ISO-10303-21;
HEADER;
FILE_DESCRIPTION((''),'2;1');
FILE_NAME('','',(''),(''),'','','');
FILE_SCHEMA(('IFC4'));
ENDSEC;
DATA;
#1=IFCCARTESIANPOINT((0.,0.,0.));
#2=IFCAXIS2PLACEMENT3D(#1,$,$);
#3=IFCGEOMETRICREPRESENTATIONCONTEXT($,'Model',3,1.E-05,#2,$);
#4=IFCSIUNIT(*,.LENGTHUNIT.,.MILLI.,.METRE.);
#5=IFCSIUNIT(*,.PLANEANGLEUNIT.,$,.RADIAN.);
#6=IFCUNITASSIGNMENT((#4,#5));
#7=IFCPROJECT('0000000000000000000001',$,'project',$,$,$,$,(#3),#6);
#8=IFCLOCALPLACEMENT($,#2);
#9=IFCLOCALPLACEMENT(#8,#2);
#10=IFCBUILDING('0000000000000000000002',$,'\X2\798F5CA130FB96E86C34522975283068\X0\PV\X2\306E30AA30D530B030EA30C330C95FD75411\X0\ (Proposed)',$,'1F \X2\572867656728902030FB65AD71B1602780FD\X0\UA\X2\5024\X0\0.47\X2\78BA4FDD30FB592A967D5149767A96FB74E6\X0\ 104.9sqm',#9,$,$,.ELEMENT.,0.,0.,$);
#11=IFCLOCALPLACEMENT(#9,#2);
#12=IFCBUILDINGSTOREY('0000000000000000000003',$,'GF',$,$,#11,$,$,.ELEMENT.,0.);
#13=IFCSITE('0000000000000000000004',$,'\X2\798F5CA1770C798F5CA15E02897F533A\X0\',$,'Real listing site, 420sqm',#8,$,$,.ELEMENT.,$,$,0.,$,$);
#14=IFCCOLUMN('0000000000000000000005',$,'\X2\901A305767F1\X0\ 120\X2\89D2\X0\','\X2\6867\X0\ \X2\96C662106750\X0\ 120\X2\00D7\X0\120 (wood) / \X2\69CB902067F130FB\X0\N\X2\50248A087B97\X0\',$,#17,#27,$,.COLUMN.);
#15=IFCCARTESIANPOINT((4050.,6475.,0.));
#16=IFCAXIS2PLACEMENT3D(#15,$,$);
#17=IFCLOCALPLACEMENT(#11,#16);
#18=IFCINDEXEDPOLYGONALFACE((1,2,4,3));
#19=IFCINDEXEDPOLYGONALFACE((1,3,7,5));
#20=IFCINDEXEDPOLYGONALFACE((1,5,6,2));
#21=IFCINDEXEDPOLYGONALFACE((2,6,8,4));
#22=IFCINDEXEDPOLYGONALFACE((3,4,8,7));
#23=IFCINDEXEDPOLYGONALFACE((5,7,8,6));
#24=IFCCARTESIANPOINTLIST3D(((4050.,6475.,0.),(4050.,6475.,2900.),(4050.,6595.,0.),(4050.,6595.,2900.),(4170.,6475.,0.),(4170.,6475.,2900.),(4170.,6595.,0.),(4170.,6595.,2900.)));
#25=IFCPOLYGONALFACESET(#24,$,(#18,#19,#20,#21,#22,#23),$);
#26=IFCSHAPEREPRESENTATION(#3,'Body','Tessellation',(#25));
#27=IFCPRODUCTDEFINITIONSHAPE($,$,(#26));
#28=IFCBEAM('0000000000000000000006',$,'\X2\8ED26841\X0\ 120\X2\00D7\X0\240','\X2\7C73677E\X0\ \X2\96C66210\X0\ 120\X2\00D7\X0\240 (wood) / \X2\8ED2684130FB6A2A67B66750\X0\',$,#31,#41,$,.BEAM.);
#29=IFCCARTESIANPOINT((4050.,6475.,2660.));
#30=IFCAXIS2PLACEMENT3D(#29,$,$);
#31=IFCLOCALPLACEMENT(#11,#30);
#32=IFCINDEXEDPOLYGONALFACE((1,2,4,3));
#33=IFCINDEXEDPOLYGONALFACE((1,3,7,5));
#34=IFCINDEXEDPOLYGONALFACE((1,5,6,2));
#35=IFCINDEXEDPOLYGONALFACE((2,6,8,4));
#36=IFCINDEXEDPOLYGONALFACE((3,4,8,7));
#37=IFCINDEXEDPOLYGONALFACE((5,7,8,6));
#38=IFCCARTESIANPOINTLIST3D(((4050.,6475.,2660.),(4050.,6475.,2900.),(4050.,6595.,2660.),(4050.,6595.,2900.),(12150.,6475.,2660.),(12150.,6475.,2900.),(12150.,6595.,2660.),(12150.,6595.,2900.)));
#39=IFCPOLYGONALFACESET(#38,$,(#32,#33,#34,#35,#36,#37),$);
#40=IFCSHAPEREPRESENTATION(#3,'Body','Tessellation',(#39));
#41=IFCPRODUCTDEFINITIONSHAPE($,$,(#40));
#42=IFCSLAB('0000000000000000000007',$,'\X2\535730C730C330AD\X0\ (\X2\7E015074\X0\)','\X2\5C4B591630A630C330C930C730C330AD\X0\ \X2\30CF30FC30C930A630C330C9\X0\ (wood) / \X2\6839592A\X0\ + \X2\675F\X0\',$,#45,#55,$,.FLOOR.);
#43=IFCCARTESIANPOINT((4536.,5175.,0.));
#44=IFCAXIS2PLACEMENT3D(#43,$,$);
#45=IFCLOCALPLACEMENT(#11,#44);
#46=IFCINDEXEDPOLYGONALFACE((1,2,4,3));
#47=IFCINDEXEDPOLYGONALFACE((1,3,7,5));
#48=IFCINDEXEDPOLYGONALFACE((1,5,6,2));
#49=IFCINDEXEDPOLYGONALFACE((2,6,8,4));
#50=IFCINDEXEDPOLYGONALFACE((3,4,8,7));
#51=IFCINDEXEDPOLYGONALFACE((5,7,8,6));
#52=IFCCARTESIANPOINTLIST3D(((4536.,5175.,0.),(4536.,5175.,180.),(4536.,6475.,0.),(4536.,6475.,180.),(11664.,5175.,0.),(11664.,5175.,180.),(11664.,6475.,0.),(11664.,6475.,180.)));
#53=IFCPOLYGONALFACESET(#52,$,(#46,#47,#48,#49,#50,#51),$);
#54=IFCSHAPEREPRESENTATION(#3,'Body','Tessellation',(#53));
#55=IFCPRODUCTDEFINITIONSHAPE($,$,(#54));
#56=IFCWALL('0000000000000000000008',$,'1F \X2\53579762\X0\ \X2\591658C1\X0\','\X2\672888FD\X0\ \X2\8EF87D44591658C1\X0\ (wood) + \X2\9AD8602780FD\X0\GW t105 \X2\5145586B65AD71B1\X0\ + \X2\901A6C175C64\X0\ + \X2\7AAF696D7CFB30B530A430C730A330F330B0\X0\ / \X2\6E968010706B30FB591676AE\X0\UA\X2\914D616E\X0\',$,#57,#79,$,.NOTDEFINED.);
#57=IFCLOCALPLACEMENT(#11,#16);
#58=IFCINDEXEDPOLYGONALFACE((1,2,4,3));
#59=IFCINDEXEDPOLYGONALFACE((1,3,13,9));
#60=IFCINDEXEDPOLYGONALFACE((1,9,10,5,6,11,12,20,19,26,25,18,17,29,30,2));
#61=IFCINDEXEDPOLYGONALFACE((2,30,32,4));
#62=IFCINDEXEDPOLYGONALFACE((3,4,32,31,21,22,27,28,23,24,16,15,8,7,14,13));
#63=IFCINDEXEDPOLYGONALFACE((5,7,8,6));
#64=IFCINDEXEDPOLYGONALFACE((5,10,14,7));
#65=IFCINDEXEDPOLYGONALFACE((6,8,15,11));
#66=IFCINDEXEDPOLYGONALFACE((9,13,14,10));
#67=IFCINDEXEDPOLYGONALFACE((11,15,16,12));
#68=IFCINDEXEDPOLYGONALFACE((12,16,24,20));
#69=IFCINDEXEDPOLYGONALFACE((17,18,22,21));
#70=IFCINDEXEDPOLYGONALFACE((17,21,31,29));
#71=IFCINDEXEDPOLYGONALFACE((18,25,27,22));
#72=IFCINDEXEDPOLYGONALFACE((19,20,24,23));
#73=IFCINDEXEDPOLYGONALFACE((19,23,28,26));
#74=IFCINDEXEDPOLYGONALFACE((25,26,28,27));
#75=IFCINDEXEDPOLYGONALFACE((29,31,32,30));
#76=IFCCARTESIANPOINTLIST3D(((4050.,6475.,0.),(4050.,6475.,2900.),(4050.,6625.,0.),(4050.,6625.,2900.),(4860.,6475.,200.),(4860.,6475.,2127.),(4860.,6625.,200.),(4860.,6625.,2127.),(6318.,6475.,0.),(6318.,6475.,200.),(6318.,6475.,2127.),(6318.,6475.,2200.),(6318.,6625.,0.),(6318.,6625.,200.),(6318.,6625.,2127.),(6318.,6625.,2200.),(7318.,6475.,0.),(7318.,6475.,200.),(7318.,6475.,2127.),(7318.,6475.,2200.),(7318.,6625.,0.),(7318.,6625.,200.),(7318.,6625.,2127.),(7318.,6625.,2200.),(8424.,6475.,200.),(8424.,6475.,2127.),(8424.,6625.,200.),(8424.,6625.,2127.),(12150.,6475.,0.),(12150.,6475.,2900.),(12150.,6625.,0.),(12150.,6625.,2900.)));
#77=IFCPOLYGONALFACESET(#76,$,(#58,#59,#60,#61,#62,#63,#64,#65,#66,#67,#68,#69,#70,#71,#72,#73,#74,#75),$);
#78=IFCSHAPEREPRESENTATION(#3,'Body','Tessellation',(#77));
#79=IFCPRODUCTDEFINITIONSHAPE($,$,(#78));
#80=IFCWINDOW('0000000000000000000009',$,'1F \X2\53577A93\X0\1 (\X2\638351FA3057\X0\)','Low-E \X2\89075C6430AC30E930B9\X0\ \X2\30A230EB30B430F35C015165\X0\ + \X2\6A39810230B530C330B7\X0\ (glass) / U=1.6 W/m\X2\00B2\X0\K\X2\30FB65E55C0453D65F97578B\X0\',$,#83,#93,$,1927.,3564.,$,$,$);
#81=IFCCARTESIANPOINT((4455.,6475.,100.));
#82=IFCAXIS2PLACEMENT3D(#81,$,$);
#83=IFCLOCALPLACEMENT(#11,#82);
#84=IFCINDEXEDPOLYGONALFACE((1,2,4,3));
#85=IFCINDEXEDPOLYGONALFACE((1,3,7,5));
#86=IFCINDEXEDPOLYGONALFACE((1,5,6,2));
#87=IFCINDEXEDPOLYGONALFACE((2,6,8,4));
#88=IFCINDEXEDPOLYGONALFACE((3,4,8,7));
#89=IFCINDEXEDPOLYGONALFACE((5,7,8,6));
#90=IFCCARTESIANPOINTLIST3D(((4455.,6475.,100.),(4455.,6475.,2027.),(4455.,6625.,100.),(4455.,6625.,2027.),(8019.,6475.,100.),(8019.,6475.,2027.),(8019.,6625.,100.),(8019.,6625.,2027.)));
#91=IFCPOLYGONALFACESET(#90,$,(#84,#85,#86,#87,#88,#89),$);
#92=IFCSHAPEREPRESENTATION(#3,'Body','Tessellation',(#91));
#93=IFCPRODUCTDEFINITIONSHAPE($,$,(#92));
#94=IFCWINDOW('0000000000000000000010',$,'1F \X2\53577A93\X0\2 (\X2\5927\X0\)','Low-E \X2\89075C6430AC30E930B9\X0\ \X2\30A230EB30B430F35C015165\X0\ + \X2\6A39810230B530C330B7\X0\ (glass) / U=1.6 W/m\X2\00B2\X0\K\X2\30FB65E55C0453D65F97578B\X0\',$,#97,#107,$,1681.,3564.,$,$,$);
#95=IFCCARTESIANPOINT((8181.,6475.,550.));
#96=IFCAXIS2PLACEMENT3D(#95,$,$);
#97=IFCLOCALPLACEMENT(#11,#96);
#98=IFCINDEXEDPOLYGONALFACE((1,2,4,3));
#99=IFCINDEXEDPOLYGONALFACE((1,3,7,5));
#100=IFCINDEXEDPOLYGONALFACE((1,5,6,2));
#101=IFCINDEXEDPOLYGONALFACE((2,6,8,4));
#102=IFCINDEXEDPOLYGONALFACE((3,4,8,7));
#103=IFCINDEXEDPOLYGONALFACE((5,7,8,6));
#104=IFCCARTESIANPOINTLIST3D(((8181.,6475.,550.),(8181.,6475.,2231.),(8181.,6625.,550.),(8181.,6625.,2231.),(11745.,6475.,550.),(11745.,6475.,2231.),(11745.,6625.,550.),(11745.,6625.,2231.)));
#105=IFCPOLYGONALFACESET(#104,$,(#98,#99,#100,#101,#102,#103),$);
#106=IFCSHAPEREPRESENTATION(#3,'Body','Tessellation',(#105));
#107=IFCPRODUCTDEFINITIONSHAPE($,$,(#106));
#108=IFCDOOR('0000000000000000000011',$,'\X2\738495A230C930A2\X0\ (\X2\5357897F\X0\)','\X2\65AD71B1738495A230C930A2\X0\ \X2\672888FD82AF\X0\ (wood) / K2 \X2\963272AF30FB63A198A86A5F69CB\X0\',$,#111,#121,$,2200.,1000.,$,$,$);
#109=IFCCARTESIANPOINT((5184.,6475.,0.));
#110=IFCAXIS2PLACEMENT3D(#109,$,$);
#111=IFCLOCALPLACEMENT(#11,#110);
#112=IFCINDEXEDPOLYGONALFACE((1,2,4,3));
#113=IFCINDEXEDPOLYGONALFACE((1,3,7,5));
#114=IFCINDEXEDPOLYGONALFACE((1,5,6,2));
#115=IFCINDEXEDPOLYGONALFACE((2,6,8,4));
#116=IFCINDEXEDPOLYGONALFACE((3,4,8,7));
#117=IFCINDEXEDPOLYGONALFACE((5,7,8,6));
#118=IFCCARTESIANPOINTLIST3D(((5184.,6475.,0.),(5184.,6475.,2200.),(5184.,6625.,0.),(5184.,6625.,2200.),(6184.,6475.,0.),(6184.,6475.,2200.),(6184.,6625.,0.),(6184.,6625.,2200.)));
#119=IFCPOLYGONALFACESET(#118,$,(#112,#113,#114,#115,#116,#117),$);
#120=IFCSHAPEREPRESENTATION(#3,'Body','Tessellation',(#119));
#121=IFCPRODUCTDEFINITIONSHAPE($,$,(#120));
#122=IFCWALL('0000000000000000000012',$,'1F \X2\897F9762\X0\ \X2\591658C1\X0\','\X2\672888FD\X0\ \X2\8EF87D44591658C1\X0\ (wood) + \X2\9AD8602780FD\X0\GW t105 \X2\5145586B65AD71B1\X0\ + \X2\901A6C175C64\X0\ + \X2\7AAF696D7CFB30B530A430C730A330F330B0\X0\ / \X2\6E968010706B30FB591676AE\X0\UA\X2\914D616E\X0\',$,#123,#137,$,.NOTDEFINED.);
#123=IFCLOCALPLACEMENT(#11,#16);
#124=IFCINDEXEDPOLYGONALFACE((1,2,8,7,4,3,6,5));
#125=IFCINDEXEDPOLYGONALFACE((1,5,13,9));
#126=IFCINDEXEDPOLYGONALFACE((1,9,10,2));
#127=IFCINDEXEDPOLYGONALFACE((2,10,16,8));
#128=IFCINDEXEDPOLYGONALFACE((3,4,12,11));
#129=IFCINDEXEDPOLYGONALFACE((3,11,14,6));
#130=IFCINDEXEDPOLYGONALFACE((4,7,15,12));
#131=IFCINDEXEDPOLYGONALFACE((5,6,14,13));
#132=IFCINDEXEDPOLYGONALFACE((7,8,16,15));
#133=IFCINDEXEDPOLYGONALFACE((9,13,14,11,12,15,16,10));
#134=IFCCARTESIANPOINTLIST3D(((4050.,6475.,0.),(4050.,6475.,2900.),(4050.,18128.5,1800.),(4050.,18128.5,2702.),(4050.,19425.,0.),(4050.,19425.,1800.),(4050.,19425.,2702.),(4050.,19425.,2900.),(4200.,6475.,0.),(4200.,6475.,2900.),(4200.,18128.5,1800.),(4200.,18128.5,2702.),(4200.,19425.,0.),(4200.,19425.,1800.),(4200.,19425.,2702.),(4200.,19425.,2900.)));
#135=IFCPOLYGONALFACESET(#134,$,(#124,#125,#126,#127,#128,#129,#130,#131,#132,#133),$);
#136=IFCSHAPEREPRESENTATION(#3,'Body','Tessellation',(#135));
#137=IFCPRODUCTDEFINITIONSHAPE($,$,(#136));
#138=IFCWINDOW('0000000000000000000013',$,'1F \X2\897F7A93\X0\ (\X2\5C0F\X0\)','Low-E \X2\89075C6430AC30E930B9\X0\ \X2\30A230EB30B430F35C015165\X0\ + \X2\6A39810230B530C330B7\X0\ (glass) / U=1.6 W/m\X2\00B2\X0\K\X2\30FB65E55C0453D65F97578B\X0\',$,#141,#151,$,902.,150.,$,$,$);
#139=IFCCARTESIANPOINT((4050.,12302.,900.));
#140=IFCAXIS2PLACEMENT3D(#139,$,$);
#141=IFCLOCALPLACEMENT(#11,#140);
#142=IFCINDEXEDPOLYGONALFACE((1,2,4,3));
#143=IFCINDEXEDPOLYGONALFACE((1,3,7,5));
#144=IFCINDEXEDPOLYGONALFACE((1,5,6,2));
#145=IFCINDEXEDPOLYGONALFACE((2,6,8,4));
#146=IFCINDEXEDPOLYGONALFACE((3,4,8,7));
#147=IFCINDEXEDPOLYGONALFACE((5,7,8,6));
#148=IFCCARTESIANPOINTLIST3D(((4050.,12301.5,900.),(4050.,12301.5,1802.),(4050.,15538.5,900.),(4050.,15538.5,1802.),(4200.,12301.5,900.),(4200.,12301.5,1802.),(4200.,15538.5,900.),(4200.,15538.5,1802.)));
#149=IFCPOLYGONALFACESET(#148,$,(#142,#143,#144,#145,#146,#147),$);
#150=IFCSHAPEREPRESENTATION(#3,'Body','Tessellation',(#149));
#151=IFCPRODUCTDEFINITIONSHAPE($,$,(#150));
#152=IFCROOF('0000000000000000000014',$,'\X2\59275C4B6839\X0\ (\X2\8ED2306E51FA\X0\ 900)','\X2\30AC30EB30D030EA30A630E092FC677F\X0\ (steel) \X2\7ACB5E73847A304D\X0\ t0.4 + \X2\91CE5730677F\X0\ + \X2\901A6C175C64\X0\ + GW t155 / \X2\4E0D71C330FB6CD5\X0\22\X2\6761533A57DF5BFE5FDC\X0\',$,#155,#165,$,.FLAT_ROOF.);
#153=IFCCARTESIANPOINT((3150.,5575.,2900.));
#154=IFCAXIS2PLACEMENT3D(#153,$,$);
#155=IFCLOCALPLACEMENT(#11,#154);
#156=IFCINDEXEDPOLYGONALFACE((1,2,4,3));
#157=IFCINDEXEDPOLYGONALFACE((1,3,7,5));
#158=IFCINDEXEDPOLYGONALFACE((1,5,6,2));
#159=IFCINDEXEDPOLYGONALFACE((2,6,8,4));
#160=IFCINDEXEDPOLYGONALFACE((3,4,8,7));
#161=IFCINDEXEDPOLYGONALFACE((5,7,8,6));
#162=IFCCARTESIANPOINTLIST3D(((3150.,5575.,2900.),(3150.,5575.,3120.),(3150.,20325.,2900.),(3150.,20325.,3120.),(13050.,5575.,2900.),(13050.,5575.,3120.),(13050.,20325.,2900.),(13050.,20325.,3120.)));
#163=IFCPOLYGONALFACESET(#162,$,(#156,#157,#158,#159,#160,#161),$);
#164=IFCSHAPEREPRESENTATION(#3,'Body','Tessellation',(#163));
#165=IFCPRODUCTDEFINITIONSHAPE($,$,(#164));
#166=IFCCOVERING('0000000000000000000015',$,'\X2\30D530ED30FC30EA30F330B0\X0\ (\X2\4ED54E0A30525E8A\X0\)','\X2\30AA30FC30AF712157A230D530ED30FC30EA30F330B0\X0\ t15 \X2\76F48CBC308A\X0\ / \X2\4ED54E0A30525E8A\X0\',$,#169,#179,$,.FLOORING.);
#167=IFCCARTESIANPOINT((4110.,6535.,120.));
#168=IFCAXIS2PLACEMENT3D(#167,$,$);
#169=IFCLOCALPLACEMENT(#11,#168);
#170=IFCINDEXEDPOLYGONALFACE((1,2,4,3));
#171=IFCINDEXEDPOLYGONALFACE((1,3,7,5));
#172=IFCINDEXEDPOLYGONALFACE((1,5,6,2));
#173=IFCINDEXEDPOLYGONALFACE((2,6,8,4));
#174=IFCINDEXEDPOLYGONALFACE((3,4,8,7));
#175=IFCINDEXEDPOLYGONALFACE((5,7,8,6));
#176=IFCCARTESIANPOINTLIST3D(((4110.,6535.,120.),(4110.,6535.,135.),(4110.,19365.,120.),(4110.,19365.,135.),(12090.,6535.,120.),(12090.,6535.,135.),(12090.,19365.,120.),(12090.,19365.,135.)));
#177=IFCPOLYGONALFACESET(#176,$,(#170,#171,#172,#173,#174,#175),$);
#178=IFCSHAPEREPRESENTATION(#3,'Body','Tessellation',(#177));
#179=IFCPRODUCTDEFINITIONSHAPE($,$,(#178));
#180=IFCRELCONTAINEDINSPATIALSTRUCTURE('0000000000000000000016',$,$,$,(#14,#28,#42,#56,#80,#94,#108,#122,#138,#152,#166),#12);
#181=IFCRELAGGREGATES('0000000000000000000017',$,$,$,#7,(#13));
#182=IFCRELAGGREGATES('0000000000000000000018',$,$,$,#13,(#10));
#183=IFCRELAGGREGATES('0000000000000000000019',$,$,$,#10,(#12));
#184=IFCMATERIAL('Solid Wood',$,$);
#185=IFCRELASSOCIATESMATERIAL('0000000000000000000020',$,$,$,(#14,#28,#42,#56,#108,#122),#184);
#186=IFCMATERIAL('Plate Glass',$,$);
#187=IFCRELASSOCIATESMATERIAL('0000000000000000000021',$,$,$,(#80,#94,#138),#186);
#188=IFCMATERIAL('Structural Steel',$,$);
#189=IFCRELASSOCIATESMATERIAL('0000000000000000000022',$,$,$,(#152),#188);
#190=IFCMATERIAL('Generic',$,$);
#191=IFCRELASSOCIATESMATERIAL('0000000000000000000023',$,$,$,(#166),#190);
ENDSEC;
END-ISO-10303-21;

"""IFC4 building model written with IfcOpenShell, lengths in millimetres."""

from ifc_helpers import new_model, si_unit, frame, frame_2d, origin, place, context, project, spatial, rectangle, extrude, material, element, fill, save


model = new_model("IFC4")

# Units and contexts
model_context = context("Model", 3, precision=1e-05, world=origin())
ifc_project = project(units=[si_unit("LENGTHUNIT", "METRE", prefix="MILLI"), si_unit("PLANEANGLEUNIT", "RADIAN")], contexts=[model_context])

# Site, building, storey
site_placement = place(None, origin())
site = spatial("IfcSite", under=ifc_project, at=site_placement, Name="福岡県福岡市西区", ObjectType="Real listing site, 420sqm", CompositionType="ELEMENT", RefElevation=0.0)
building_placement = place(site_placement, origin())
building = spatial("IfcBuilding", under=site, at=building_placement, Name="福岡・雨水利用とPVのオフグリッド志向 (Proposed)", ObjectType="1F 在来木造・断熱性能UA値0.47確保・太陽光発電瓦 104.9sqm", CompositionType="ELEMENT", ElevationOfRefHeight=0.0, ElevationOfTerrain=0.0)
storey_placement = place(building_placement, origin())
storey = spatial("IfcBuildingStorey", under=building, at=storey_placement, Name="GF", CompositionType="ELEMENT", Elevation=0.0)

# Column
ifc_material_1 = material(Name="Solid Wood")
column_1_placement = place(storey_placement, frame((4050.0, 6475.0, 0.0)))
element("IfcColumn", 1, at=column_1_placement, inside=storey, material=ifc_material_1, Name="通し柱 120角", Description="桧 集成材 120×120 (wood) / 構造柱・N値計算", PredefinedType="COLUMN", context=model_context, shape_type="SweptSolid", body=[
    extrude(rectangle(XDim=120.0, YDim=120.0, at=frame_2d((60.0, 60.0))), frame((4050.0, 6475.0, 0.0)), (0.0, 0.0, 1.0), 2900.0),
])

# Beam
beam_1_placement = place(storey_placement, frame((4050.0, 6475.0, 2660.0)))
element("IfcBeam", 2, at=beam_1_placement, inside=storey, material=ifc_material_1, Name="軒桁 120×240", Description="米松 集成 120×240 (wood) / 軒桁・横架材", PredefinedType="BEAM", context=model_context, shape_type="SweptSolid", body=[
    extrude(rectangle(XDim=8100.0, YDim=120.0, at=frame_2d((4050.0, 60.0))), frame((4050.0, 6475.0, 2660.0)), (0.0, 0.0, 1.0), 240.0),
])

# Slab
slab_1_placement = place(storey_placement, frame((4536.0, 5175.0, 0.0)))
element("IfcSlab", 3, at=slab_1_placement, inside=storey, material=ifc_material_1, Name="南デッキ (縁側)", Description="屋外ウッドデッキ ハードウッド (wood) / 根太 + 束", PredefinedType="FLOOR", context=model_context, shape_type="SweptSolid", body=[
    extrude(rectangle(XDim=7128.0, YDim=1300.0, at=frame_2d((3564.0, 650.0))), frame((4536.0, 5175.0, 0.0)), (0.0, 0.0, 1.0), 180.0),
])

# Wall, openings, windows, door
wall_1_placement = place(storey_placement, frame((4050.0, 6475.0, 0.0)))
wall_1 = element("IfcWall", 4, at=wall_1_placement, inside=storey, material=ifc_material_1, Name="1F 南面 外壁", Description="木製 軸組外壁 (wood) + 高性能GW t105 充填断熱 + 通気層 + 窯業系サイディング / 準耐火・外皮UA配慮", PredefinedType="NOTDEFINED", context=model_context, shape_type="SweptSolid", body=[
    extrude(rectangle(XDim=8100.0, YDim=150.0, at=frame_2d((4050.0, 75.0))), frame((4050.0, 6475.0, 0.0)), (0.0, 0.0, 1.0), 2900.0),
])
opening_1_placement = place(storey_placement, frame((4455.0, 6475.0, 100.0)))
opening_1 = element("IfcOpeningElement", 5, at=opening_1_placement, cuts=wall_1, PredefinedType="NOTDEFINED", context=model_context, shape_type="SweptSolid", body=[
    extrude(rectangle(XDim=3564.0, YDim=150.0, at=frame_2d((1782.0, 75.0))), frame((4455.0, 6475.0, 100.0)), (0.0, 0.0, 1.0), 1927.0),
])
opening_2_placement = place(storey_placement, frame((8181.0, 6475.0, 550.0)))
opening_2 = element("IfcOpeningElement", 6, at=opening_2_placement, cuts=wall_1, PredefinedType="NOTDEFINED", context=model_context, shape_type="SweptSolid", body=[
    extrude(rectangle(XDim=3564.0, YDim=150.0, at=frame_2d((1782.0, 75.0))), frame((8181.0, 6475.0, 550.0)), (0.0, 0.0, 1.0), 1681.0),
])
opening_3_placement = place(storey_placement, frame((5184.0, 6475.0, 0.0)))
opening_3 = element("IfcOpeningElement", 7, at=opening_3_placement, cuts=wall_1, PredefinedType="NOTDEFINED", context=model_context, shape_type="SweptSolid", body=[
    extrude(rectangle(XDim=1000.0, YDim=150.0, at=frame_2d((500.0, 75.0))), frame((5184.0, 6475.0, 0.0)), (0.0, 0.0, 1.0), 2200.0),
])
ifc_material_2 = material(Name="Plate Glass")
window_1_placement = place(storey_placement, frame((4455.0, 6475.0, 100.0)))
window_1 = element("IfcWindow", 8, at=window_1_placement, inside=storey, material=ifc_material_2, Name="1F 南窓1 (掃出し)", Description="Low-E 複層ガラス アルゴン封入 + 樹脂サッシ (glass) / U=1.6 W/m²K・日射取得型", OverallHeight=1927.0, OverallWidth=3564.0, context=model_context, shape_type="SweptSolid", body=[
    extrude(rectangle(XDim=3564.0, YDim=150.0, at=frame_2d((1782.0, 75.0))), frame((4455.0, 6475.0, 100.0)), (0.0, 0.0, 1.0), 1927.0),
])
fill(opening_1, window_1)
window_2_placement = place(storey_placement, frame((8181.0, 6475.0, 550.0)))
window_2 = element("IfcWindow", 9, at=window_2_placement, inside=storey, material=ifc_material_2, Name="1F 南窓2 (大)", Description="Low-E 複層ガラス アルゴン封入 + 樹脂サッシ (glass) / U=1.6 W/m²K・日射取得型", OverallHeight=1681.0, OverallWidth=3564.0, context=model_context, shape_type="SweptSolid", body=[
    extrude(rectangle(XDim=3564.0, YDim=150.0, at=frame_2d((1782.0, 75.0))), frame((8181.0, 6475.0, 550.0)), (0.0, 0.0, 1.0), 1681.0),
])
fill(opening_2, window_2)
door_placement = place(storey_placement, frame((5184.0, 6475.0, 0.0)))
door = element("IfcDoor", 10, at=door_placement, inside=storey, material=ifc_material_1, Name="玄関ドア (南西)", Description="断熱玄関ドア 木製芯 (wood) / K2 防犯・採風機構", OverallHeight=2200.0, OverallWidth=1000.0, context=model_context, shape_type="SweptSolid", body=[
    extrude(rectangle(XDim=1000.0, YDim=150.0, at=frame_2d((500.0, 75.0))), frame((5184.0, 6475.0, 0.0)), (0.0, 0.0, 1.0), 2200.0),
])
fill(opening_3, door)

# Wall, opening, window
wall_2_placement = place(storey_placement, frame((4050.0, 6475.0, 0.0)))
wall_2 = element("IfcWall", 11, at=wall_2_placement, inside=storey, material=ifc_material_1, Name="1F 西面 外壁", Description="木製 軸組外壁 (wood) + 高性能GW t105 充填断熱 + 通気層 + 窯業系サイディング / 準耐火・外皮UA配慮", PredefinedType="NOTDEFINED", context=model_context, shape_type="SweptSolid", body=[
    extrude(rectangle(XDim=150.0, YDim=12950.0, at=frame_2d((75.0, 6475.0))), frame((4050.0, 6475.0, 0.0)), (0.0, 0.0, 1.0), 2900.0),
])
opening_4_placement = place(storey_placement, frame((4050.0, 12302.0, 900.0)))
opening_4 = element("IfcOpeningElement", 12, at=opening_4_placement, cuts=wall_2, PredefinedType="NOTDEFINED", context=model_context, shape_type="SweptSolid", body=[
    extrude(rectangle(XDim=150.0, YDim=3237.0, at=frame_2d((75.0, 1618.0))), frame((4050.0, 12302.0, 900.0)), (0.0, 0.0, 1.0), 902.0),
])
window_3_placement = place(storey_placement, frame((4050.0, 12302.0, 900.0)))
window_3 = element("IfcWindow", 13, at=window_3_placement, inside=storey, material=ifc_material_2, Name="1F 西窓 (小)", Description="Low-E 複層ガラス アルゴン封入 + 樹脂サッシ (glass) / U=1.6 W/m²K・日射取得型", OverallHeight=902.0, OverallWidth=150.0, context=model_context, shape_type="SweptSolid", body=[
    extrude(rectangle(XDim=150.0, YDim=3237.0, at=frame_2d((75.0, 1618.0))), frame((4050.0, 12302.0, 900.0)), (0.0, 0.0, 1.0), 902.0),
])
fill(opening_4, window_3)

# Roof
ifc_material_3 = material(Name="Structural Steel")
roof_placement = place(storey_placement, frame((3150.0, 5575.0, 2900.0)))
element("IfcRoof", 14, at=roof_placement, inside=storey, material=ifc_material_3, Name="大屋根 (軒の出 900)", Description="ガルバリウム鋼板 (steel) 立平葺き t0.4 + 野地板 + 通気層 + GW t155 / 不燃・法22条区域対応", PredefinedType="FLAT_ROOF", context=model_context, shape_type="SweptSolid", body=[
    extrude(rectangle(XDim=9900.0, YDim=14750.0, at=frame_2d((4950.0, 7375.0))), frame((3150.0, 5575.0, 2900.0)), (0.0, 0.0, 1.0), 220.0),
])

# Covering
ifc_material_4 = material(Name="Generic")
covering_1_placement = place(storey_placement, frame((4110.0, 6535.0, 120.0)))
element("IfcCovering", 15, at=covering_1_placement, inside=storey, material=ifc_material_4, Name="フローリング (仕上げ床)", Description="オーク無垢フローリング t15 直貼り / 仕上げ床", PredefinedType="FLOORING", context=model_context, shape_type="SweptSolid", body=[
    extrude(rectangle(XDim=7980.0, YDim=12830.0, at=frame_2d((3990.0, 6415.0))), frame((4110.0, 6535.0, 120.0)), (0.0, 0.0, 1.0), 15.0),
])

save(model, "model.ifc")
